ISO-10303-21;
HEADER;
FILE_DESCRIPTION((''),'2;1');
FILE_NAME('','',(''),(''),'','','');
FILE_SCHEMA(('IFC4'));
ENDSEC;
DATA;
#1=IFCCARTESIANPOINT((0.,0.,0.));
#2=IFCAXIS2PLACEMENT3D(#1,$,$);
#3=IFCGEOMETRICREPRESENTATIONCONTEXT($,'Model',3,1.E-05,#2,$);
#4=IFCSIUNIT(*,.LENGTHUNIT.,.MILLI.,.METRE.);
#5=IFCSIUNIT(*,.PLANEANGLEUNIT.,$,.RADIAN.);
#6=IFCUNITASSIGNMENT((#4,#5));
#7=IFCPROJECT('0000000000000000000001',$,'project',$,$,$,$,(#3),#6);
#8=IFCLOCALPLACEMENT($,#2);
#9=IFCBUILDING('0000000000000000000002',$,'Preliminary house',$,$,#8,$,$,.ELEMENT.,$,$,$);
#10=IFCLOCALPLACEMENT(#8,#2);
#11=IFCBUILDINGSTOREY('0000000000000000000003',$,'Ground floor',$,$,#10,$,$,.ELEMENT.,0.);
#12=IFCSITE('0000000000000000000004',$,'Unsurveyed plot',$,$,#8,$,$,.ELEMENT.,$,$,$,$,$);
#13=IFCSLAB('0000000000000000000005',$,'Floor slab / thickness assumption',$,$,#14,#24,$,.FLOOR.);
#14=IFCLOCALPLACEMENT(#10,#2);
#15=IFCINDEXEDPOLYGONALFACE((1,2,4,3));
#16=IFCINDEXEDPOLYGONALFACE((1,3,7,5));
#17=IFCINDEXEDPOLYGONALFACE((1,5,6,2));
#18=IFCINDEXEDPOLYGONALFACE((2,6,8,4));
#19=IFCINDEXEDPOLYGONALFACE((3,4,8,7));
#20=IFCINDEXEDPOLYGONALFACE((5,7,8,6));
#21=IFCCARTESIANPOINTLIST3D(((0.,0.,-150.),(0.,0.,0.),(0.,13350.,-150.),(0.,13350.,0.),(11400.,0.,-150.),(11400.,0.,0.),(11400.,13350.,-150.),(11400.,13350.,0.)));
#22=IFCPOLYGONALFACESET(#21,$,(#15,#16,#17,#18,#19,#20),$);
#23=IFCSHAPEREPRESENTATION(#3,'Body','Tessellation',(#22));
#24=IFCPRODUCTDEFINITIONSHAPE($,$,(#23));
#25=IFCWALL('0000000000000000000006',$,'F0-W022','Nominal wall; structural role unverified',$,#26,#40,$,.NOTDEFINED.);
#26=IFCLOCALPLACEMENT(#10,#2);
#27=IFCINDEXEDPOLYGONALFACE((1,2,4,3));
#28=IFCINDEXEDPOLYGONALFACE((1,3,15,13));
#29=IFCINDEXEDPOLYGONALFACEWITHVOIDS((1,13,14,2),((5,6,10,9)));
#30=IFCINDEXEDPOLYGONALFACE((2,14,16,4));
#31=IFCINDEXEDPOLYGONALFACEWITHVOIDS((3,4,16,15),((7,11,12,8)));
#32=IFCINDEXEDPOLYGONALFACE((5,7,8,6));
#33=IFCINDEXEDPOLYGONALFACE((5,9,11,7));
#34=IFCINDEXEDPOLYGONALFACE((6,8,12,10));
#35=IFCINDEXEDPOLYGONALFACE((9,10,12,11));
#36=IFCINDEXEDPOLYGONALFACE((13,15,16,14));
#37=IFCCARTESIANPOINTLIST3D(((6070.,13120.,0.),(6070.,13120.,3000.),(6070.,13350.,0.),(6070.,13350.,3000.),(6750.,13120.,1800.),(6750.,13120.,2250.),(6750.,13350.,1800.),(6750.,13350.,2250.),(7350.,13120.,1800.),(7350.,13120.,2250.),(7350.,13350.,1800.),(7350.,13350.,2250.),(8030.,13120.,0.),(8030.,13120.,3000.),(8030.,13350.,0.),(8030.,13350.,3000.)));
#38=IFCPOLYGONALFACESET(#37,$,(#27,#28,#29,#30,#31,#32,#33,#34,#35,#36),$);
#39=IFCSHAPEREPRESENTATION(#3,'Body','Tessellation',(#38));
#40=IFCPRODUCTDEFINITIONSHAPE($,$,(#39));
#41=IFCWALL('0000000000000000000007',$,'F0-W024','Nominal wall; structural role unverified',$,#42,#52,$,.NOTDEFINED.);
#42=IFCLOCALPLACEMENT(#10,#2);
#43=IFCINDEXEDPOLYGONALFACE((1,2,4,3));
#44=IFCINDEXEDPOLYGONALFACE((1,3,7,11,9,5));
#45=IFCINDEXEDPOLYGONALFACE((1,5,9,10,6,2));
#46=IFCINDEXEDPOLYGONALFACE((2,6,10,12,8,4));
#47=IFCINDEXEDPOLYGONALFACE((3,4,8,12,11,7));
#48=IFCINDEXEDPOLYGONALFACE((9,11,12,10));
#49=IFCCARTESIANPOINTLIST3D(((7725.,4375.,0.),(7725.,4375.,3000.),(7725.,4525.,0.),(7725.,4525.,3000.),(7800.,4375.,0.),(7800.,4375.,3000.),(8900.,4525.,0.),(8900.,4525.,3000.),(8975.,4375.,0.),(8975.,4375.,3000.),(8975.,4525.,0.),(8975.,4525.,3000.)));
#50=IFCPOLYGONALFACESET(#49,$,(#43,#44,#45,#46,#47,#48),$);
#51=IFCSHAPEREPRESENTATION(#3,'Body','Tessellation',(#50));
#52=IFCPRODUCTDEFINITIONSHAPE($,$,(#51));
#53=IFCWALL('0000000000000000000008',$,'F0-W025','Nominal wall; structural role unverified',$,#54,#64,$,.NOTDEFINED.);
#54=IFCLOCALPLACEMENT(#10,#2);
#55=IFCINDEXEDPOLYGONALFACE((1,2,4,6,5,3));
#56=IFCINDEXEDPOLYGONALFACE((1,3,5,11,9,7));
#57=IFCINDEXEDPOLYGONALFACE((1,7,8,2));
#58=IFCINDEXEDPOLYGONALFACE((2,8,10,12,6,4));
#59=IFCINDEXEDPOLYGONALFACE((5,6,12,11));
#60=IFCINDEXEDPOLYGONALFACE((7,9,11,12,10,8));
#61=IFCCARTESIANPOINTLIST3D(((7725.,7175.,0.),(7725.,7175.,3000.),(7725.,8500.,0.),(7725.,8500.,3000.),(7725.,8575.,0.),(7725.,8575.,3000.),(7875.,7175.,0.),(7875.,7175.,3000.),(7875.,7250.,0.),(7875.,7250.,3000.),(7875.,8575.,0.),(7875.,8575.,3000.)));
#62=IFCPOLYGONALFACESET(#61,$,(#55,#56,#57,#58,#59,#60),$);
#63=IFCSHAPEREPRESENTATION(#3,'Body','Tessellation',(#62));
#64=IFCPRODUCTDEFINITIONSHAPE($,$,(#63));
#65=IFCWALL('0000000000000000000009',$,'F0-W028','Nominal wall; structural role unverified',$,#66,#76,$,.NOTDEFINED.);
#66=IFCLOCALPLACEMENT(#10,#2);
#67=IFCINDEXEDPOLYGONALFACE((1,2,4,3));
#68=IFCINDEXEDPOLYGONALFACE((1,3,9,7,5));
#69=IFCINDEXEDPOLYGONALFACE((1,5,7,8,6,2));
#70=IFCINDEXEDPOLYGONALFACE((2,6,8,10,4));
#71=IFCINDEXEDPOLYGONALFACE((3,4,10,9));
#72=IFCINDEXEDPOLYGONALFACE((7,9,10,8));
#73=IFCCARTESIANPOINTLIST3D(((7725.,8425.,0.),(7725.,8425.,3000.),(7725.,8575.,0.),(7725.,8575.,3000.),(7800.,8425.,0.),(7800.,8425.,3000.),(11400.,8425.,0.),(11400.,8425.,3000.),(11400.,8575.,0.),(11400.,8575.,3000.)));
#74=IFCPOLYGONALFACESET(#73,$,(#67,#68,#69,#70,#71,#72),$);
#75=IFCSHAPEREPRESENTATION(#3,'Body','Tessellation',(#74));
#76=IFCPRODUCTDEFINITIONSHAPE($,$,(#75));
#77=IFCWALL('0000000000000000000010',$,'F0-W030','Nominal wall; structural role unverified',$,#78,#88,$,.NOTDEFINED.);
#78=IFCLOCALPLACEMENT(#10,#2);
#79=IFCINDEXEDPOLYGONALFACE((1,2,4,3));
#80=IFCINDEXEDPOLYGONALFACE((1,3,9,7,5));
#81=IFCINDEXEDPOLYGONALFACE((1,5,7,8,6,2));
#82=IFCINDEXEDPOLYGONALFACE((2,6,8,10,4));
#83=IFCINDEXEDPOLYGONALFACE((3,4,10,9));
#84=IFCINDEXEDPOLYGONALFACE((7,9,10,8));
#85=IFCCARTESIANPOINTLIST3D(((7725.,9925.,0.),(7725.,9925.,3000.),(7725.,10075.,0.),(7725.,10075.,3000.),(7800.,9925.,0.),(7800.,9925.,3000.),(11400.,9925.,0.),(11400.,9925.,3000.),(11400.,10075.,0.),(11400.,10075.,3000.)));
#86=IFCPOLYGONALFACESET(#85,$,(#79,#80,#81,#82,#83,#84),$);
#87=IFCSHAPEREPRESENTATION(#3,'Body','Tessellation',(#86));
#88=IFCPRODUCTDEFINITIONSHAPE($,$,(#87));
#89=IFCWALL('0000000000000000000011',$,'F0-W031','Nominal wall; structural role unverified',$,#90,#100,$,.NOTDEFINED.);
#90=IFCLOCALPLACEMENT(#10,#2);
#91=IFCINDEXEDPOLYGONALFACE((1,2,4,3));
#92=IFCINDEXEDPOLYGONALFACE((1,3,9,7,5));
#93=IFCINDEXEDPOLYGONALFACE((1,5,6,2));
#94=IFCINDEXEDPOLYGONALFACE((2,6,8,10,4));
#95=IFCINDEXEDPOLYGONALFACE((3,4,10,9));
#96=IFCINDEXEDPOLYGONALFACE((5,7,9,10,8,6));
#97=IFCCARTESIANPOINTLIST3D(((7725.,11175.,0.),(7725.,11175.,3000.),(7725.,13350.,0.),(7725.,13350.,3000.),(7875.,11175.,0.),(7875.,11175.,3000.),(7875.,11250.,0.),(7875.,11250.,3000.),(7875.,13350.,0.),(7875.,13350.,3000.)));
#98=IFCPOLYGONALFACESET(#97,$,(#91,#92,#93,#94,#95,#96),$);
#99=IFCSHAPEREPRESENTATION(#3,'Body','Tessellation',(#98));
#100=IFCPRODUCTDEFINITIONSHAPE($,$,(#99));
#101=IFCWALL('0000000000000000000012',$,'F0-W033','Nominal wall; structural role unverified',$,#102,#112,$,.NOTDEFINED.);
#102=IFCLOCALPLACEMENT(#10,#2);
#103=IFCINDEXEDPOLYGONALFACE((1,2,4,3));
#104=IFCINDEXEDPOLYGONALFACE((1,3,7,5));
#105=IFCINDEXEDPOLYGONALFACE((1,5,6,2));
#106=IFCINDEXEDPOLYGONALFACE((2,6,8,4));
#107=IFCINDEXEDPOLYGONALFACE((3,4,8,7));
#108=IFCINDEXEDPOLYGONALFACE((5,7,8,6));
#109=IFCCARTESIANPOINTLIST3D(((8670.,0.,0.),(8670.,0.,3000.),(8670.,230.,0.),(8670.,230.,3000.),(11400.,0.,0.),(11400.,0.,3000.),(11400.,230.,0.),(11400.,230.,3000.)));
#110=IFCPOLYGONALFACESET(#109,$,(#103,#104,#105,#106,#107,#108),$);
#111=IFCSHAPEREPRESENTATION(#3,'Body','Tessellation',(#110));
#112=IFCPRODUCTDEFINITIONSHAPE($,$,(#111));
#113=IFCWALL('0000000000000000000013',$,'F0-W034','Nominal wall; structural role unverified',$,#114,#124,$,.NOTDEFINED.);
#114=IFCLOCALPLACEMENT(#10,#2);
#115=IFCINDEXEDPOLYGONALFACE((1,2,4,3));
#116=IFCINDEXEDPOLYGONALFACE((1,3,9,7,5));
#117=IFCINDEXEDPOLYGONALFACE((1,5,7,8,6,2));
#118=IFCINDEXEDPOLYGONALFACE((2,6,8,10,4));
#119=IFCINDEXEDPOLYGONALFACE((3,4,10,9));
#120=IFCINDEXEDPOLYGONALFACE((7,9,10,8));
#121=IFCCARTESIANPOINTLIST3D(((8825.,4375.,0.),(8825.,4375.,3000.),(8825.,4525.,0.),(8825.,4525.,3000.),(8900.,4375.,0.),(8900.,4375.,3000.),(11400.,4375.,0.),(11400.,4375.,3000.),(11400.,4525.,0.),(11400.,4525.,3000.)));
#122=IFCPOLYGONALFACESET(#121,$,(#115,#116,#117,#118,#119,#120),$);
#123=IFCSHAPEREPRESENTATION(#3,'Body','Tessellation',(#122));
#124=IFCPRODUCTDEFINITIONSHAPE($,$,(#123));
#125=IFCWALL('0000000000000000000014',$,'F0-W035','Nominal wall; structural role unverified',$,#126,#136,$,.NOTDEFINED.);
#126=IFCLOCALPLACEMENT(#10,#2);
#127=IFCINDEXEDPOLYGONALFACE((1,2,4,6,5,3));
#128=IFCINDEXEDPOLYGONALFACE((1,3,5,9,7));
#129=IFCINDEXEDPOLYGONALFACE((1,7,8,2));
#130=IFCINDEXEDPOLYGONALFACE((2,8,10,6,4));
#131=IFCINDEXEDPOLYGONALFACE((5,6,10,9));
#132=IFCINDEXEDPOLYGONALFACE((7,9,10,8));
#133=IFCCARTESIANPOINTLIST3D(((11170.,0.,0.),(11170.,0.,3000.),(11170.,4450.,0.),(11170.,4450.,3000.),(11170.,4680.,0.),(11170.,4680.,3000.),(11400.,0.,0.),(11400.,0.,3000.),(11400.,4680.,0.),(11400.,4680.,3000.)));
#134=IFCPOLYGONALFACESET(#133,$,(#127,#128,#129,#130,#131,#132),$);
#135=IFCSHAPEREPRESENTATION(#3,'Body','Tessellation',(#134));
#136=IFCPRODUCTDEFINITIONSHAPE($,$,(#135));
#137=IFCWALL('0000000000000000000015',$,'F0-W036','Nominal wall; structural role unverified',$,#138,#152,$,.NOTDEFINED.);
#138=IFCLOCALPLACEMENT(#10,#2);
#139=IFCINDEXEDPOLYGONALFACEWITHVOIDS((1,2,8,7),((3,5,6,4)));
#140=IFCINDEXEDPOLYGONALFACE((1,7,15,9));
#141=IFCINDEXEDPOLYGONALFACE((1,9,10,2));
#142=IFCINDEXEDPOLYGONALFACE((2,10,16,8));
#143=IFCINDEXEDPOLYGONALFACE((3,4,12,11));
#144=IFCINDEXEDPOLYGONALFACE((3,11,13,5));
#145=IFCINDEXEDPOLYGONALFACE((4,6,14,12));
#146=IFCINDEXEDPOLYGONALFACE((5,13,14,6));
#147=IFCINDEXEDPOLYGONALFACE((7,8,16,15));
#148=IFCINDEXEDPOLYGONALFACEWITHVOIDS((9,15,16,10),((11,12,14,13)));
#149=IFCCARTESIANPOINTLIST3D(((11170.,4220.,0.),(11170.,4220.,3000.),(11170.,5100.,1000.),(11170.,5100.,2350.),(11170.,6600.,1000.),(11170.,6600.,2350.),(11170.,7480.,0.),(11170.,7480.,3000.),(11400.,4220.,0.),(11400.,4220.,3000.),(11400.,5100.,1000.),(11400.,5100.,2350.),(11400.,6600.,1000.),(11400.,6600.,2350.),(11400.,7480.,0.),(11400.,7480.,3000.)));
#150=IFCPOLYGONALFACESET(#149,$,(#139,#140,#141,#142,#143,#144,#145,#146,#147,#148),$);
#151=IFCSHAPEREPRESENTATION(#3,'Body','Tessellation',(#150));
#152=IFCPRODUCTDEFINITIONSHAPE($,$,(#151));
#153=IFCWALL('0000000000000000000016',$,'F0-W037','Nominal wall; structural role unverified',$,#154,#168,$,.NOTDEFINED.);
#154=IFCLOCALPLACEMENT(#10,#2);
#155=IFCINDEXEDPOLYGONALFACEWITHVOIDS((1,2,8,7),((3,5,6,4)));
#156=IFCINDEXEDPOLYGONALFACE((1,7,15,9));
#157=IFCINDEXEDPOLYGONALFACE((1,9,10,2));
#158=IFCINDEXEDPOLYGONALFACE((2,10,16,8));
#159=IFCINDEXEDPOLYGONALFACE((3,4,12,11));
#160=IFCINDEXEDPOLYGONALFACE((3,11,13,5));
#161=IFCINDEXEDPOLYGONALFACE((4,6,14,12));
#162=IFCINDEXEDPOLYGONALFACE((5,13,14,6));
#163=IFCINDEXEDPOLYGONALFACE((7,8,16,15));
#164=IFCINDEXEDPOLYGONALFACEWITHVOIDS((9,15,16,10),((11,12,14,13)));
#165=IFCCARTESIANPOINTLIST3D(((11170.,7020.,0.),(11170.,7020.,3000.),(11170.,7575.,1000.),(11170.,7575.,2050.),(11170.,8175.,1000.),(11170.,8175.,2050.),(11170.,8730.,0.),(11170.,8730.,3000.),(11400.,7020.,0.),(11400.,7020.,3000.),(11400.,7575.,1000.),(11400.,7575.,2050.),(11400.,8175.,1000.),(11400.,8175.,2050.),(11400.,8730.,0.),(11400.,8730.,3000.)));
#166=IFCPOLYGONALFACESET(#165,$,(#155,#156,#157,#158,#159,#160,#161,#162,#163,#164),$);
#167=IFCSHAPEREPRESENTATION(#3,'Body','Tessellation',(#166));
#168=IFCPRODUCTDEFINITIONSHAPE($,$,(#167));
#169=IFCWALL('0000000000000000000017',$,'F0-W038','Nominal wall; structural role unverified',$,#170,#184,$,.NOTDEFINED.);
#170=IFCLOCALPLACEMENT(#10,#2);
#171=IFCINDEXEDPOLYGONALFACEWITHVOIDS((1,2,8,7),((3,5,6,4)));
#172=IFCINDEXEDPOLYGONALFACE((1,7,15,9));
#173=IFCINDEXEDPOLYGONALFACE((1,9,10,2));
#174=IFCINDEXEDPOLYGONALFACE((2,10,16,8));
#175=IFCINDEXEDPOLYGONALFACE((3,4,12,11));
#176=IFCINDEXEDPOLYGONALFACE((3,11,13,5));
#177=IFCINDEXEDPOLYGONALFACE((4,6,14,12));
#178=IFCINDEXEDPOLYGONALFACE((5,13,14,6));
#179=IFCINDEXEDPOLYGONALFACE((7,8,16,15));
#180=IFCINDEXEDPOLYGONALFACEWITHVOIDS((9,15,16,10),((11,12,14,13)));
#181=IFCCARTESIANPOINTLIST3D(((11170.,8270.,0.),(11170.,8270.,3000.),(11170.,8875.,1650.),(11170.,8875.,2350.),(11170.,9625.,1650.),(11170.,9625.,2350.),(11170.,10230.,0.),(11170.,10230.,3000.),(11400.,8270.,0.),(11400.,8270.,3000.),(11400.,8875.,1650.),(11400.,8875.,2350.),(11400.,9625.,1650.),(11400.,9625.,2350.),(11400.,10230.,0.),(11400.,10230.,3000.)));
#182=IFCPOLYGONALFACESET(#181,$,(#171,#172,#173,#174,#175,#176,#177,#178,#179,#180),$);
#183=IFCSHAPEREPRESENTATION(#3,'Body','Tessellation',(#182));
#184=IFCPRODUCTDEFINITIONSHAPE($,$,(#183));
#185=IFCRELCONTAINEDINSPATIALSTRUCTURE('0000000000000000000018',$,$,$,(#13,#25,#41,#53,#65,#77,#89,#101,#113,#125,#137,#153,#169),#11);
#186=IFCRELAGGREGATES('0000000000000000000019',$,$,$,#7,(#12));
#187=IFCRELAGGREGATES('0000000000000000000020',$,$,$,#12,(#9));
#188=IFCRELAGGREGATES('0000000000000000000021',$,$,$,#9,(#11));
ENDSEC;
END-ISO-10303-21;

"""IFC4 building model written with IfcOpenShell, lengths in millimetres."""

from ifc_helpers import new_model, si_unit, frame, origin, place, context, project, spatial, polyline, outline, extrude, element, save


model = new_model("IFC4")

# Units and contexts
model_context = context("Model", 3, precision=1e-05, world=origin())
ifc_project = project(units=[si_unit("LENGTHUNIT", "METRE", prefix="MILLI"), si_unit("PLANEANGLEUNIT", "RADIAN")], contexts=[model_context])

# Site, building, storey
placement_1 = place(None, origin())
site = spatial("IfcSite", under=ifc_project, at=placement_1, Name="Unsurveyed plot", CompositionType="ELEMENT")
building = spatial("IfcBuilding", under=site, at=placement_1, Name="Preliminary house", CompositionType="ELEMENT")
placement_2 = place(placement_1, origin())
storey = spatial("IfcBuildingStorey", under=building, at=placement_2, Name="Ground floor", CompositionType="ELEMENT", Elevation=0.0)

# Slab
element("IfcSlab", 1, at=placement_2, inside=storey, Name="Floor slab / thickness assumption", PredefinedType="FLOOR", context=model_context, shape_type="SweptSolid", body=[
    extrude(outline(polyline([(11400.0, 0.0), (11400.0, 13350.0), (0.0, 13350.0), (0.0, 0.0), (11400.0, 0.0)])), frame((0.0, 0.0, -150.0)), (0.0, 0.0, 1.0), 150.0),
])

# Wall, opening
wall_1 = element("IfcWall", 2, at=placement_2, inside=storey, Name="F0-W022", Description="Nominal wall; structural role unverified", PredefinedType="NOTDEFINED", context=model_context, shape_type="SweptSolid", body=[
    extrude(outline(polyline([(8030.0, 13120.0), (6300.0, 13120.0), (6070.0, 13120.0), (6070.0, 13350.0), (8030.0, 13350.0), (8030.0, 13120.0)])), origin(), (0.0, 0.0, 1.0), 3000.0),
])
element("IfcOpeningElement", 3, at=placement_2, cuts=wall_1, PredefinedType="OPENING", context=model_context, shape_type="SweptSolid", body=[
    extrude(outline(polyline([(6750.0, 12705.0), (7350.0, 12705.0), (7350.0, 13765.0), (6750.0, 13765.0), (6750.0, 12705.0)])), frame((0.0, 0.0, 1800.0)), (0.0, 0.0, 1.0), 450.0),
])

# Walls
element("IfcWall", 4, at=placement_2, inside=storey, Name="F0-W024", Description="Nominal wall; structural role unverified", PredefinedType="NOTDEFINED", context=model_context, shape_type="SweptSolid", body=[
    extrude(outline(polyline([(8975.0, 4525.0), (8975.0, 4375.0), (7800.0, 4375.0), (7725.0, 4375.0), (7725.0, 4525.0), (8900.0, 4525.0), (8975.0, 4525.0)])), origin(), (0.0, 0.0, 1.0), 3000.0),
])
element("IfcWall", 5, at=placement_2, inside=storey, Name="F0-W025", Description="Nominal wall; structural role unverified", PredefinedType="NOTDEFINED", context=model_context, shape_type="SweptSolid", body=[
    extrude(outline(polyline([(7725.0, 8575.0), (7875.0, 8575.0), (7875.0, 7250.0), (7875.0, 7175.0), (7725.0, 7175.0), (7725.0, 8500.0), (7725.0, 8575.0)])), origin(), (0.0, 0.0, 1.0), 3000.0),
])

# Wall
element("IfcWall", 6, at=placement_2, inside=storey, Name="F0-W028", Description="Nominal wall; structural role unverified", PredefinedType="NOTDEFINED", context=model_context, shape_type="SweptSolid", body=[
    extrude(outline(polyline([(7800.0, 8425.0), (7725.0, 8425.0), (7725.0, 8575.0), (11400.0, 8575.0), (11400.0, 8425.0), (7800.0, 8425.0)])), origin(), (0.0, 0.0, 1.0), 3000.0),
])

# Walls
element("IfcWall", 7, at=placement_2, inside=storey, Name="F0-W030", Description="Nominal wall; structural role unverified", PredefinedType="NOTDEFINED", context=model_context, shape_type="SweptSolid", body=[
    extrude(outline(polyline([(7800.0, 9925.0), (7725.0, 9925.0), (7725.0, 10075.0), (11400.0, 10075.0), (11400.0, 9925.0), (7800.0, 9925.0)])), origin(), (0.0, 0.0, 1.0), 3000.0),
])
element("IfcWall", 8, at=placement_2, inside=storey, Name="F0-W031", Description="Nominal wall; structural role unverified", PredefinedType="NOTDEFINED", context=model_context, shape_type="SweptSolid", body=[
    extrude(outline(polyline([(7875.0, 11250.0), (7875.0, 11175.0), (7725.0, 11175.0), (7725.0, 13350.0), (7875.0, 13350.0), (7875.0, 11250.0)])), origin(), (0.0, 0.0, 1.0), 3000.0),
])

# Walls
element("IfcWall", 9, at=placement_2, inside=storey, Name="F0-W033", Description="Nominal wall; structural role unverified", PredefinedType="NOTDEFINED", context=model_context, shape_type="SweptSolid", body=[
    extrude(outline(polyline([(8670.0, 230.0), (11400.0, 230.0), (11400.0, 0.0), (8670.0, 0.0), (8670.0, 230.0)])), origin(), (0.0, 0.0, 1.0), 3000.0),
])
element("IfcWall", 10, at=placement_2, inside=storey, Name="F0-W034", Description="Nominal wall; structural role unverified", PredefinedType="NOTDEFINED", context=model_context, shape_type="SweptSolid", body=[
    extrude(outline(polyline([(8900.0, 4375.0), (8825.0, 4375.0), (8825.0, 4525.0), (11400.0, 4525.0), (11400.0, 4375.0), (8900.0, 4375.0)])), origin(), (0.0, 0.0, 1.0), 3000.0),
])
element("IfcWall", 11, at=placement_2, inside=storey, Name="F0-W035", Description="Nominal wall; structural role unverified", PredefinedType="NOTDEFINED", context=model_context, shape_type="SweptSolid", body=[
    extrude(outline(polyline([(11170.0, 4680.0), (11400.0, 4680.0), (11400.0, 0.0), (11170.0, 0.0), (11170.0, 4450.0), (11170.0, 4680.0)])), origin(), (0.0, 0.0, 1.0), 3000.0),
])

# Walls, openings
wall_2 = element("IfcWall", 12, at=placement_2, inside=storey, Name="F0-W036", Description="Nominal wall; structural role unverified", PredefinedType="NOTDEFINED", context=model_context, shape_type="SweptSolid", body=[
    extrude(outline(polyline([(11170.0, 7480.0), (11400.0, 7480.0), (11400.0, 4220.0), (11170.0, 4220.0), (11170.0, 7250.0), (11170.0, 7480.0)])), origin(), (0.0, 0.0, 1.0), 3000.0),
])
element("IfcOpeningElement", 13, at=placement_2, cuts=wall_2, PredefinedType="OPENING", context=model_context, shape_type="SweptSolid", body=[
    extrude(outline(polyline([(11815.0, 5100.0), (11815.0, 6600.0), (10755.0, 6600.0), (10755.0, 5100.0), (11815.0, 5100.0)])), frame((0.0, 0.0, 1000.0)), (0.0, 0.0, 1.0), 1350.0),
])
wall_3 = element("IfcWall", 14, at=placement_2, inside=storey, Name="F0-W037", Description="Nominal wall; structural role unverified", PredefinedType="NOTDEFINED", context=model_context, shape_type="SweptSolid", body=[
    extrude(outline(polyline([(11170.0, 8730.0), (11400.0, 8730.0), (11400.0, 7020.0), (11170.0, 7020.0), (11170.0, 8500.0), (11170.0, 8730.0)])), origin(), (0.0, 0.0, 1.0), 3000.0),
])
element("IfcOpeningElement", 15, at=placement_2, cuts=wall_3, PredefinedType="OPENING", context=model_context, shape_type="SweptSolid", body=[
    extrude(outline(polyline([(11815.0, 7575.0), (11815.0, 8175.0), (10755.0, 8175.0), (10755.0, 7575.0), (11815.0, 7575.0)])), frame((0.0, 0.0, 1000.0)), (0.0, 0.0, 1.0), 1050.0),
])
wall_4 = element("IfcWall", 16, at=placement_2, inside=storey, Name="F0-W038", Description="Nominal wall; structural role unverified", PredefinedType="NOTDEFINED", context=model_context, shape_type="SweptSolid", body=[
    extrude(outline(polyline([(11170.0, 10230.0), (11400.0, 10230.0), (11400.0, 8270.0), (11170.0, 8270.0), (11170.0, 10000.0), (11170.0, 10230.0)])), origin(), (0.0, 0.0, 1.0), 3000.0),
])
element("IfcOpeningElement", 17, at=placement_2, cuts=wall_4, PredefinedType="OPENING", context=model_context, shape_type="SweptSolid", body=[
    extrude(outline(polyline([(11815.0, 8875.0), (11815.0, 9625.0), (10755.0, 9625.0), (10755.0, 8875.0), (11815.0, 8875.0)])), frame((0.0, 0.0, 1650.0)), (0.0, 0.0, 1.0), 700.0),
])

save(model, "model.ifc")
